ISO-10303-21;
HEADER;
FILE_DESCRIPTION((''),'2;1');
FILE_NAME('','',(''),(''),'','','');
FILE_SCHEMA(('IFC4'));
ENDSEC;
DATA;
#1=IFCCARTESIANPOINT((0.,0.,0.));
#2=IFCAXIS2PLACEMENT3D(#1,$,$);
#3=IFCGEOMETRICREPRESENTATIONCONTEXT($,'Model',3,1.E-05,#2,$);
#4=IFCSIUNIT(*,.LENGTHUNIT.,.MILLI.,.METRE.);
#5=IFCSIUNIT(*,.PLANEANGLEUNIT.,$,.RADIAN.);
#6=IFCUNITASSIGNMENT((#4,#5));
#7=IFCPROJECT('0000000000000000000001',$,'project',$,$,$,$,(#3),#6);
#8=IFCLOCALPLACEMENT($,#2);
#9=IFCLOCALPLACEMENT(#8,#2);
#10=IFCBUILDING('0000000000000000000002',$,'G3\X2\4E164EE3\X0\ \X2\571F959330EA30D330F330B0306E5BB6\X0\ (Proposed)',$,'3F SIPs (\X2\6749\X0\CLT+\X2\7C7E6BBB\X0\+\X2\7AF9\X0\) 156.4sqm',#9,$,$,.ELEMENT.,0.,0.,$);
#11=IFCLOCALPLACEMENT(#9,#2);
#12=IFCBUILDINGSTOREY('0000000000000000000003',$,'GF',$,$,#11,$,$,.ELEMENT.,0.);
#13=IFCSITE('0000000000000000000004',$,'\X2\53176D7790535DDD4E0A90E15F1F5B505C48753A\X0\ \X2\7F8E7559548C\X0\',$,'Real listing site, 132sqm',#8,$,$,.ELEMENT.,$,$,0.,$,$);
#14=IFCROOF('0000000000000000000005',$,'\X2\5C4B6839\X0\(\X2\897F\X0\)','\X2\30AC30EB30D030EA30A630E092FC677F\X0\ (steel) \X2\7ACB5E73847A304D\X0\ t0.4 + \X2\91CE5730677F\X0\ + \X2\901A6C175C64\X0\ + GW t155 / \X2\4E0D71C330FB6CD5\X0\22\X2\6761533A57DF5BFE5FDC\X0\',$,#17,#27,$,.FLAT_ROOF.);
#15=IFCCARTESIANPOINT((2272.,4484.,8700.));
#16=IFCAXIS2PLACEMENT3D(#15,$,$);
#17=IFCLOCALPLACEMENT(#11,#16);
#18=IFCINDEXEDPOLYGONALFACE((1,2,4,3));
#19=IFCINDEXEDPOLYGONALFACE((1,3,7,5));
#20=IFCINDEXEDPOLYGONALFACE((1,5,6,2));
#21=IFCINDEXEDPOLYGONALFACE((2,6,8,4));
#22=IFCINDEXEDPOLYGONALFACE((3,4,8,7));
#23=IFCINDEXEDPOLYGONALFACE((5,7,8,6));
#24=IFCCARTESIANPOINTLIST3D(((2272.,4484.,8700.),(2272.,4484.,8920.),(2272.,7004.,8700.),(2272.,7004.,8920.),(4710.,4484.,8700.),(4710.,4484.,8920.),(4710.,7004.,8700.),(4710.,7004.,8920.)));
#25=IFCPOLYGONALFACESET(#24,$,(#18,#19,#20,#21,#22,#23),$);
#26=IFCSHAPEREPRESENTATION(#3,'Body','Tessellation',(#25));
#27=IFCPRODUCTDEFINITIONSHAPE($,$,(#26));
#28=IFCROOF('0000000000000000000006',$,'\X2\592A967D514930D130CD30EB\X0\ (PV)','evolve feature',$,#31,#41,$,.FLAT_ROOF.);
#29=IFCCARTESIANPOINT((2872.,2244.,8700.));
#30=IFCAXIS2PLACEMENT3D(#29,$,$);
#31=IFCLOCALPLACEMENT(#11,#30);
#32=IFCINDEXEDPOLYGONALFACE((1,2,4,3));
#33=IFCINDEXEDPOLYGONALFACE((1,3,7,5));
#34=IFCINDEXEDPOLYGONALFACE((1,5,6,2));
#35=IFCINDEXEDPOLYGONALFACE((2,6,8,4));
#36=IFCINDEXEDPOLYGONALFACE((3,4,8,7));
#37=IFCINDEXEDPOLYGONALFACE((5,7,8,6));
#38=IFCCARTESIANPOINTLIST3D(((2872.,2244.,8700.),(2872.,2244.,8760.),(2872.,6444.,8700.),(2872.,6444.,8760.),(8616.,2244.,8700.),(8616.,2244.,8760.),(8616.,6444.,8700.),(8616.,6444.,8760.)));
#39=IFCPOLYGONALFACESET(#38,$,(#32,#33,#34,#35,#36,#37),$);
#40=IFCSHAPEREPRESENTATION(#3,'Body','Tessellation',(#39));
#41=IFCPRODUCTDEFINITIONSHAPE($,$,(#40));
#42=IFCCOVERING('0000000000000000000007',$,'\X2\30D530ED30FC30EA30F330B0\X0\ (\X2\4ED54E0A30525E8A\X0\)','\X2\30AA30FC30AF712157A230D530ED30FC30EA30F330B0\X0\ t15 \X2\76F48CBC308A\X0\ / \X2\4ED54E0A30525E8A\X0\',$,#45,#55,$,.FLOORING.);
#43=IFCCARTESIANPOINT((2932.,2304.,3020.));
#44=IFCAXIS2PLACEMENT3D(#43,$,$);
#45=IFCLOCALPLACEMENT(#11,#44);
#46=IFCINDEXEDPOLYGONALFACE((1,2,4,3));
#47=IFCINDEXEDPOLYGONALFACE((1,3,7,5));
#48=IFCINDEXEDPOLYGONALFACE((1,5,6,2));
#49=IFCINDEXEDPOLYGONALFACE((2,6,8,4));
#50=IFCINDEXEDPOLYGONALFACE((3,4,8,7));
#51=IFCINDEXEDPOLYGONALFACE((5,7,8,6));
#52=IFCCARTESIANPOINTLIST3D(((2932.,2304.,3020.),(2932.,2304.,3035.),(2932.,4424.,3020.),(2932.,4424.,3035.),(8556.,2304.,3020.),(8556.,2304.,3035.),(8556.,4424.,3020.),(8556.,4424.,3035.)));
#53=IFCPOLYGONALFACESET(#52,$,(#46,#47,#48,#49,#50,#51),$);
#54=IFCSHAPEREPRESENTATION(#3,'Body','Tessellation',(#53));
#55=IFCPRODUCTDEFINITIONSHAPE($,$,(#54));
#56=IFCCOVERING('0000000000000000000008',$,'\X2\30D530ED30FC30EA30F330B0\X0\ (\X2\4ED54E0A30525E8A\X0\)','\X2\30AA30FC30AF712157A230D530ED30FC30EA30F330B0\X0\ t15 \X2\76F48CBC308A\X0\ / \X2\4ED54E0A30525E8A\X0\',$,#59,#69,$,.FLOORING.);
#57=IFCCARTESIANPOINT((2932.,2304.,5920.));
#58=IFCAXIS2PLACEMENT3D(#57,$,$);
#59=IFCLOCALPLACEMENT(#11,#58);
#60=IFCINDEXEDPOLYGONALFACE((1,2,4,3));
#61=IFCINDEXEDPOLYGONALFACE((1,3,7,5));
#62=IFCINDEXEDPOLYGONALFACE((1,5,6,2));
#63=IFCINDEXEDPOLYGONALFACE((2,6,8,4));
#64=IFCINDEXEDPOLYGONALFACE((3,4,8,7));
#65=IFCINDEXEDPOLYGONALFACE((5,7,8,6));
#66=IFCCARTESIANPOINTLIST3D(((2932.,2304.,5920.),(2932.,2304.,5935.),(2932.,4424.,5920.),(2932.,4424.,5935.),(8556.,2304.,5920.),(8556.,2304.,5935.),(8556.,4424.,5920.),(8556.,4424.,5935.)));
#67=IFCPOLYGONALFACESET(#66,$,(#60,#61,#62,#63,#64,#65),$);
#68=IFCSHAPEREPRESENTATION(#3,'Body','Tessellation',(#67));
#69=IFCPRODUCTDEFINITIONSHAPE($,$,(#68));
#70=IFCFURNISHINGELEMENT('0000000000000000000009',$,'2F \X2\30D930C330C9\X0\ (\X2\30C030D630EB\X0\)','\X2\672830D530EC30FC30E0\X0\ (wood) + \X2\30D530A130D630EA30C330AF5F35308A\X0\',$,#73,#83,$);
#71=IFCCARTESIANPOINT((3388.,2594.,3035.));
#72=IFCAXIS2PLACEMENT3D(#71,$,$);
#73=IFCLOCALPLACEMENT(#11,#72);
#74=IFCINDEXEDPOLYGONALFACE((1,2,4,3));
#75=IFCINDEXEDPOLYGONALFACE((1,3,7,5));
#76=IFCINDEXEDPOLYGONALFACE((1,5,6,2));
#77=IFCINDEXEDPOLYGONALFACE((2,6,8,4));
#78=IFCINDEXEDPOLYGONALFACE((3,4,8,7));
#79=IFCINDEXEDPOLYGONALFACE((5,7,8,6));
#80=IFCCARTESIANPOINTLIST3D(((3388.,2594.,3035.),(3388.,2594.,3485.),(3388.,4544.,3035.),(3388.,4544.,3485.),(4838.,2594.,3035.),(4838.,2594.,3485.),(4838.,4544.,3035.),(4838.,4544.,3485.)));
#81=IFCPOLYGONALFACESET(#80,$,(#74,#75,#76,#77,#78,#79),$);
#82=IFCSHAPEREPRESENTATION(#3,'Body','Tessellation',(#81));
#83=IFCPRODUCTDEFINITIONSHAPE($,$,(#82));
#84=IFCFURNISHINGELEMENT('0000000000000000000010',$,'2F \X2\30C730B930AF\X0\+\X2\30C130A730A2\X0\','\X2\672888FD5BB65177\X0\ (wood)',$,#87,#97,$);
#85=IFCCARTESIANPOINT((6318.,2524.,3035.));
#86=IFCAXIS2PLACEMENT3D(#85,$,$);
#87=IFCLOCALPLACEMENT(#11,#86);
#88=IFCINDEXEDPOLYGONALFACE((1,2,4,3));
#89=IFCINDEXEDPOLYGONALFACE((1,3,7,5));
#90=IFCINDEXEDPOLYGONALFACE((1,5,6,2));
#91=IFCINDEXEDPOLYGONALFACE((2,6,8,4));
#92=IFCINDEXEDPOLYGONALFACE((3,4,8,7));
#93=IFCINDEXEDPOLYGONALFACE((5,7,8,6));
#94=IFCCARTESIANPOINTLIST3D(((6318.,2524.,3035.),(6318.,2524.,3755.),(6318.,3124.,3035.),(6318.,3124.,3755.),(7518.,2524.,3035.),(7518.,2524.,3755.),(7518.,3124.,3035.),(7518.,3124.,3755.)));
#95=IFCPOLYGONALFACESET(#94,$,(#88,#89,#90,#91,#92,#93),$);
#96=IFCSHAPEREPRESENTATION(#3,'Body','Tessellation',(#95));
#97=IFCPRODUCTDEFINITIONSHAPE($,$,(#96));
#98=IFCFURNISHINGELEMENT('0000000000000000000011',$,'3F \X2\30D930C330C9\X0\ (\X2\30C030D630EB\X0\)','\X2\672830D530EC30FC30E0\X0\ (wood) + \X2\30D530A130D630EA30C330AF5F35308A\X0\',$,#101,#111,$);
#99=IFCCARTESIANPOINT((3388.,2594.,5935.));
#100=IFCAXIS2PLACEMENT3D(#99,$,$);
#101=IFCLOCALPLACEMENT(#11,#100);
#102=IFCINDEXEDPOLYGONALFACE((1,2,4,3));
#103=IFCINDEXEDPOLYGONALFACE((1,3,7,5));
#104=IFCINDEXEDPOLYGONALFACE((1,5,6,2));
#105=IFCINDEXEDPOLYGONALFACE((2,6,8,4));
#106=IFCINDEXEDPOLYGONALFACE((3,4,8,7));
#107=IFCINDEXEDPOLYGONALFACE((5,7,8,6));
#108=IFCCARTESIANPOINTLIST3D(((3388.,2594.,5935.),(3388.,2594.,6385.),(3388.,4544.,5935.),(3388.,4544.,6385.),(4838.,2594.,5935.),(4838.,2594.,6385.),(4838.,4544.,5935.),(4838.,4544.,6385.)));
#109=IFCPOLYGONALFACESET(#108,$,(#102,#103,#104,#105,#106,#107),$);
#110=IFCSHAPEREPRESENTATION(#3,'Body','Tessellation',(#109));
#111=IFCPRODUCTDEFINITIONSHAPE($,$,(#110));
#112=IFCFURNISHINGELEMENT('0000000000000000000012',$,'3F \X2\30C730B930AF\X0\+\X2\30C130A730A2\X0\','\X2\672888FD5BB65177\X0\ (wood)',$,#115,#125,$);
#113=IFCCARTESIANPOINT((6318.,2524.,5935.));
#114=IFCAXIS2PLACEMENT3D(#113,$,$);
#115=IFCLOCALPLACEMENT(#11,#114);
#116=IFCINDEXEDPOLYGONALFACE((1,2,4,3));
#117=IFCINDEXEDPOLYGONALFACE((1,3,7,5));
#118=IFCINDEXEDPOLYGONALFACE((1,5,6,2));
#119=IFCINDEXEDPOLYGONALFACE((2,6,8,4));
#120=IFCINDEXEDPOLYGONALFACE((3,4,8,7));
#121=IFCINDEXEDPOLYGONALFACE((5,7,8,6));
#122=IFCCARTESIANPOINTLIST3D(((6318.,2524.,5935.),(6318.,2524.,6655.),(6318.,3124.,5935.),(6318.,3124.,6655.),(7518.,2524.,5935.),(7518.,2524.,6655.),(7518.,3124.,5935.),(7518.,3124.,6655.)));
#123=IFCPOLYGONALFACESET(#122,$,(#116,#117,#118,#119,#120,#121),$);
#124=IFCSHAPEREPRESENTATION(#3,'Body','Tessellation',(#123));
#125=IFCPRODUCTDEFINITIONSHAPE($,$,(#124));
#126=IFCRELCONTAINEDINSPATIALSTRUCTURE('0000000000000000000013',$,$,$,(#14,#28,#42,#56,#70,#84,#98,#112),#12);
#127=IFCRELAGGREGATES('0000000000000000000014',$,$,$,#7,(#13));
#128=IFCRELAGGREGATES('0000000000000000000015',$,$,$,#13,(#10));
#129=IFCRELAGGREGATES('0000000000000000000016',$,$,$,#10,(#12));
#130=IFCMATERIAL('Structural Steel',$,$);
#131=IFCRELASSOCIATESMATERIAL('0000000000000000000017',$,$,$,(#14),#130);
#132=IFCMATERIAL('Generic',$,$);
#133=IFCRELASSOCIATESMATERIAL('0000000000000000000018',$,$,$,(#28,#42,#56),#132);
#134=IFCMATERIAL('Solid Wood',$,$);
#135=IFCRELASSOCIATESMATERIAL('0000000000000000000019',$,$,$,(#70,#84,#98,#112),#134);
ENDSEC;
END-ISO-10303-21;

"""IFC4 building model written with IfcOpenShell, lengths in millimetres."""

from ifc_helpers import new_model, si_unit, frame, frame_2d, origin, place, context, project, spatial, rectangle, extrude, material, element, save


model = new_model("IFC4")

# Units and contexts
model_context = context("Model", 3, precision=1e-05, world=origin())
ifc_project = project(units=[si_unit("LENGTHUNIT", "METRE", prefix="MILLI"), si_unit("PLANEANGLEUNIT", "RADIAN")], contexts=[model_context])

# Site, building, storey
site_placement = place(None, origin())
site = spatial("IfcSite", under=ifc_project, at=site_placement, Name="北海道川上郡弟子屈町 美留和", ObjectType="Real listing site, 132sqm", CompositionType="ELEMENT", RefElevation=0.0)
building_placement = place(site_placement, origin())
building = spatial("IfcBuilding", under=site, at=building_placement, Name="G3世代 土間リビングの家 (Proposed)", ObjectType="3F SIPs (杉CLT+籾殻+竹) 156.4sqm", CompositionType="ELEMENT", ElevationOfRefHeight=0.0, ElevationOfTerrain=0.0)
storey_placement = place(building_placement, origin())
storey = spatial("IfcBuildingStorey", under=building, at=storey_placement, Name="GF", CompositionType="ELEMENT", Elevation=0.0)

# Shared definitions
ifc_material_1 = material(Name="Solid Wood")

# Roofs
ifc_material_2 = material(Name="Structural Steel")
roof_1_placement = place(storey_placement, frame((2272.0, 4484.0, 8700.0)))
element("IfcRoof", 1, at=roof_1_placement, inside=storey, material=ifc_material_2, Name="屋根(西)", Description="ガルバリウム鋼板 (steel) 立平葺き t0.4 + 野地板 + 通気層 + GW t155 / 不燃・法22条区域対応", PredefinedType="FLAT_ROOF", context=model_context, shape_type="SweptSolid", body=[
    extrude(rectangle(XDim=2438.0, YDim=2520.0, at=frame_2d((1219.0, 1260.0))), frame((2272.0, 4484.0, 8700.0)), (0.0, 0.0, 1.0), 220.0),
])
ifc_material_3 = material(Name="Generic")
roof_2_placement = place(storey_placement, frame((2872.0, 2244.0, 8700.0)))
element("IfcRoof", 2, at=roof_2_placement, inside=storey, material=ifc_material_3, Name="太陽光パネル (PV)", Description="evolve feature", PredefinedType="FLAT_ROOF", context=model_context, shape_type="SweptSolid", body=[
    extrude(rectangle(XDim=5744.0, YDim=4200.0, at=frame_2d((2872.0, 2100.0))), frame((2872.0, 2244.0, 8700.0)), (0.0, 0.0, 1.0), 60.0),
])

# Coverings
covering_1_placement = place(storey_placement, frame((2932.0, 2304.0, 3020.0)))
element("IfcCovering", 3, at=covering_1_placement, inside=storey, material=ifc_material_3, Name="フローリング (仕上げ床)", Description="オーク無垢フローリング t15 直貼り / 仕上げ床", PredefinedType="FLOORING", context=model_context, shape_type="SweptSolid", body=[
    extrude(rectangle(XDim=5624.0, YDim=2120.0, at=frame_2d((2812.0, 1060.0))), frame((2932.0, 2304.0, 3020.0)), (0.0, 0.0, 1.0), 15.0),
])
covering_2_placement = place(storey_placement, frame((2932.0, 2304.0, 5920.0)))
element("IfcCovering", 4, at=covering_2_placement, inside=storey, material=ifc_material_3, Name="フローリング (仕上げ床)", Description="オーク無垢フローリング t15 直貼り / 仕上げ床", PredefinedType="FLOORING", context=model_context, shape_type="SweptSolid", body=[
    extrude(rectangle(XDim=5624.0, YDim=2120.0, at=frame_2d((2812.0, 1060.0))), frame((2932.0, 2304.0, 5920.0)), (0.0, 0.0, 1.0), 15.0),
])

# Furnishing elements
furnishing_1_placement = place(storey_placement, frame((3388.0, 2594.0, 3035.0)))
element("IfcFurnishingElement", 5, at=furnishing_1_placement, inside=storey, material=ifc_material_1, Name="2F ベッド (ダブル)", Description="木フレーム (wood) + ファブリック張り", context=model_context, shape_type="SweptSolid", body=[
    extrude(rectangle(XDim=1450.0, YDim=1950.0, at=frame_2d((725.0, 975.0))), frame((3388.0, 2594.0, 3035.0)), (0.0, 0.0, 1.0), 450.0),
])
furnishing_2_placement = place(storey_placement, frame((6318.0, 2524.0, 3035.0)))
element("IfcFurnishingElement", 6, at=furnishing_2_placement, inside=storey, material=ifc_material_1, Name="2F デスク+チェア", Description="木製家具 (wood)", context=model_context, shape_type="SweptSolid", body=[
    extrude(rectangle(XDim=1200.0, YDim=600.0, at=frame_2d((600.0, 300.0))), frame((6318.0, 2524.0, 3035.0)), (0.0, 0.0, 1.0), 720.0),
])
furnishing_3_placement = place(storey_placement, frame((3388.0, 2594.0, 5935.0)))
element("IfcFurnishingElement", 7, at=furnishing_3_placement, inside=storey, material=ifc_material_1, Name="3F ベッド (ダブル)", Description="木フレーム (wood) + ファブリック張り", context=model_context, shape_type="SweptSolid", body=[
    extrude(rectangle(XDim=1450.0, YDim=1950.0, at=frame_2d((725.0, 975.0))), frame((3388.0, 2594.0, 5935.0)), (0.0, 0.0, 1.0), 450.0),
])
furnishing_4_placement = place(storey_placement, frame((6318.0, 2524.0, 5935.0)))
element("IfcFurnishingElement", 8, at=furnishing_4_placement, inside=storey, material=ifc_material_1, Name="3F デスク+チェア", Description="木製家具 (wood)", context=model_context, shape_type="SweptSolid", body=[
    extrude(rectangle(XDim=1200.0, YDim=600.0, at=frame_2d((600.0, 300.0))), frame((6318.0, 2524.0, 5935.0)), (0.0, 0.0, 1.0), 720.0),
])

save(model, "model.ifc")
